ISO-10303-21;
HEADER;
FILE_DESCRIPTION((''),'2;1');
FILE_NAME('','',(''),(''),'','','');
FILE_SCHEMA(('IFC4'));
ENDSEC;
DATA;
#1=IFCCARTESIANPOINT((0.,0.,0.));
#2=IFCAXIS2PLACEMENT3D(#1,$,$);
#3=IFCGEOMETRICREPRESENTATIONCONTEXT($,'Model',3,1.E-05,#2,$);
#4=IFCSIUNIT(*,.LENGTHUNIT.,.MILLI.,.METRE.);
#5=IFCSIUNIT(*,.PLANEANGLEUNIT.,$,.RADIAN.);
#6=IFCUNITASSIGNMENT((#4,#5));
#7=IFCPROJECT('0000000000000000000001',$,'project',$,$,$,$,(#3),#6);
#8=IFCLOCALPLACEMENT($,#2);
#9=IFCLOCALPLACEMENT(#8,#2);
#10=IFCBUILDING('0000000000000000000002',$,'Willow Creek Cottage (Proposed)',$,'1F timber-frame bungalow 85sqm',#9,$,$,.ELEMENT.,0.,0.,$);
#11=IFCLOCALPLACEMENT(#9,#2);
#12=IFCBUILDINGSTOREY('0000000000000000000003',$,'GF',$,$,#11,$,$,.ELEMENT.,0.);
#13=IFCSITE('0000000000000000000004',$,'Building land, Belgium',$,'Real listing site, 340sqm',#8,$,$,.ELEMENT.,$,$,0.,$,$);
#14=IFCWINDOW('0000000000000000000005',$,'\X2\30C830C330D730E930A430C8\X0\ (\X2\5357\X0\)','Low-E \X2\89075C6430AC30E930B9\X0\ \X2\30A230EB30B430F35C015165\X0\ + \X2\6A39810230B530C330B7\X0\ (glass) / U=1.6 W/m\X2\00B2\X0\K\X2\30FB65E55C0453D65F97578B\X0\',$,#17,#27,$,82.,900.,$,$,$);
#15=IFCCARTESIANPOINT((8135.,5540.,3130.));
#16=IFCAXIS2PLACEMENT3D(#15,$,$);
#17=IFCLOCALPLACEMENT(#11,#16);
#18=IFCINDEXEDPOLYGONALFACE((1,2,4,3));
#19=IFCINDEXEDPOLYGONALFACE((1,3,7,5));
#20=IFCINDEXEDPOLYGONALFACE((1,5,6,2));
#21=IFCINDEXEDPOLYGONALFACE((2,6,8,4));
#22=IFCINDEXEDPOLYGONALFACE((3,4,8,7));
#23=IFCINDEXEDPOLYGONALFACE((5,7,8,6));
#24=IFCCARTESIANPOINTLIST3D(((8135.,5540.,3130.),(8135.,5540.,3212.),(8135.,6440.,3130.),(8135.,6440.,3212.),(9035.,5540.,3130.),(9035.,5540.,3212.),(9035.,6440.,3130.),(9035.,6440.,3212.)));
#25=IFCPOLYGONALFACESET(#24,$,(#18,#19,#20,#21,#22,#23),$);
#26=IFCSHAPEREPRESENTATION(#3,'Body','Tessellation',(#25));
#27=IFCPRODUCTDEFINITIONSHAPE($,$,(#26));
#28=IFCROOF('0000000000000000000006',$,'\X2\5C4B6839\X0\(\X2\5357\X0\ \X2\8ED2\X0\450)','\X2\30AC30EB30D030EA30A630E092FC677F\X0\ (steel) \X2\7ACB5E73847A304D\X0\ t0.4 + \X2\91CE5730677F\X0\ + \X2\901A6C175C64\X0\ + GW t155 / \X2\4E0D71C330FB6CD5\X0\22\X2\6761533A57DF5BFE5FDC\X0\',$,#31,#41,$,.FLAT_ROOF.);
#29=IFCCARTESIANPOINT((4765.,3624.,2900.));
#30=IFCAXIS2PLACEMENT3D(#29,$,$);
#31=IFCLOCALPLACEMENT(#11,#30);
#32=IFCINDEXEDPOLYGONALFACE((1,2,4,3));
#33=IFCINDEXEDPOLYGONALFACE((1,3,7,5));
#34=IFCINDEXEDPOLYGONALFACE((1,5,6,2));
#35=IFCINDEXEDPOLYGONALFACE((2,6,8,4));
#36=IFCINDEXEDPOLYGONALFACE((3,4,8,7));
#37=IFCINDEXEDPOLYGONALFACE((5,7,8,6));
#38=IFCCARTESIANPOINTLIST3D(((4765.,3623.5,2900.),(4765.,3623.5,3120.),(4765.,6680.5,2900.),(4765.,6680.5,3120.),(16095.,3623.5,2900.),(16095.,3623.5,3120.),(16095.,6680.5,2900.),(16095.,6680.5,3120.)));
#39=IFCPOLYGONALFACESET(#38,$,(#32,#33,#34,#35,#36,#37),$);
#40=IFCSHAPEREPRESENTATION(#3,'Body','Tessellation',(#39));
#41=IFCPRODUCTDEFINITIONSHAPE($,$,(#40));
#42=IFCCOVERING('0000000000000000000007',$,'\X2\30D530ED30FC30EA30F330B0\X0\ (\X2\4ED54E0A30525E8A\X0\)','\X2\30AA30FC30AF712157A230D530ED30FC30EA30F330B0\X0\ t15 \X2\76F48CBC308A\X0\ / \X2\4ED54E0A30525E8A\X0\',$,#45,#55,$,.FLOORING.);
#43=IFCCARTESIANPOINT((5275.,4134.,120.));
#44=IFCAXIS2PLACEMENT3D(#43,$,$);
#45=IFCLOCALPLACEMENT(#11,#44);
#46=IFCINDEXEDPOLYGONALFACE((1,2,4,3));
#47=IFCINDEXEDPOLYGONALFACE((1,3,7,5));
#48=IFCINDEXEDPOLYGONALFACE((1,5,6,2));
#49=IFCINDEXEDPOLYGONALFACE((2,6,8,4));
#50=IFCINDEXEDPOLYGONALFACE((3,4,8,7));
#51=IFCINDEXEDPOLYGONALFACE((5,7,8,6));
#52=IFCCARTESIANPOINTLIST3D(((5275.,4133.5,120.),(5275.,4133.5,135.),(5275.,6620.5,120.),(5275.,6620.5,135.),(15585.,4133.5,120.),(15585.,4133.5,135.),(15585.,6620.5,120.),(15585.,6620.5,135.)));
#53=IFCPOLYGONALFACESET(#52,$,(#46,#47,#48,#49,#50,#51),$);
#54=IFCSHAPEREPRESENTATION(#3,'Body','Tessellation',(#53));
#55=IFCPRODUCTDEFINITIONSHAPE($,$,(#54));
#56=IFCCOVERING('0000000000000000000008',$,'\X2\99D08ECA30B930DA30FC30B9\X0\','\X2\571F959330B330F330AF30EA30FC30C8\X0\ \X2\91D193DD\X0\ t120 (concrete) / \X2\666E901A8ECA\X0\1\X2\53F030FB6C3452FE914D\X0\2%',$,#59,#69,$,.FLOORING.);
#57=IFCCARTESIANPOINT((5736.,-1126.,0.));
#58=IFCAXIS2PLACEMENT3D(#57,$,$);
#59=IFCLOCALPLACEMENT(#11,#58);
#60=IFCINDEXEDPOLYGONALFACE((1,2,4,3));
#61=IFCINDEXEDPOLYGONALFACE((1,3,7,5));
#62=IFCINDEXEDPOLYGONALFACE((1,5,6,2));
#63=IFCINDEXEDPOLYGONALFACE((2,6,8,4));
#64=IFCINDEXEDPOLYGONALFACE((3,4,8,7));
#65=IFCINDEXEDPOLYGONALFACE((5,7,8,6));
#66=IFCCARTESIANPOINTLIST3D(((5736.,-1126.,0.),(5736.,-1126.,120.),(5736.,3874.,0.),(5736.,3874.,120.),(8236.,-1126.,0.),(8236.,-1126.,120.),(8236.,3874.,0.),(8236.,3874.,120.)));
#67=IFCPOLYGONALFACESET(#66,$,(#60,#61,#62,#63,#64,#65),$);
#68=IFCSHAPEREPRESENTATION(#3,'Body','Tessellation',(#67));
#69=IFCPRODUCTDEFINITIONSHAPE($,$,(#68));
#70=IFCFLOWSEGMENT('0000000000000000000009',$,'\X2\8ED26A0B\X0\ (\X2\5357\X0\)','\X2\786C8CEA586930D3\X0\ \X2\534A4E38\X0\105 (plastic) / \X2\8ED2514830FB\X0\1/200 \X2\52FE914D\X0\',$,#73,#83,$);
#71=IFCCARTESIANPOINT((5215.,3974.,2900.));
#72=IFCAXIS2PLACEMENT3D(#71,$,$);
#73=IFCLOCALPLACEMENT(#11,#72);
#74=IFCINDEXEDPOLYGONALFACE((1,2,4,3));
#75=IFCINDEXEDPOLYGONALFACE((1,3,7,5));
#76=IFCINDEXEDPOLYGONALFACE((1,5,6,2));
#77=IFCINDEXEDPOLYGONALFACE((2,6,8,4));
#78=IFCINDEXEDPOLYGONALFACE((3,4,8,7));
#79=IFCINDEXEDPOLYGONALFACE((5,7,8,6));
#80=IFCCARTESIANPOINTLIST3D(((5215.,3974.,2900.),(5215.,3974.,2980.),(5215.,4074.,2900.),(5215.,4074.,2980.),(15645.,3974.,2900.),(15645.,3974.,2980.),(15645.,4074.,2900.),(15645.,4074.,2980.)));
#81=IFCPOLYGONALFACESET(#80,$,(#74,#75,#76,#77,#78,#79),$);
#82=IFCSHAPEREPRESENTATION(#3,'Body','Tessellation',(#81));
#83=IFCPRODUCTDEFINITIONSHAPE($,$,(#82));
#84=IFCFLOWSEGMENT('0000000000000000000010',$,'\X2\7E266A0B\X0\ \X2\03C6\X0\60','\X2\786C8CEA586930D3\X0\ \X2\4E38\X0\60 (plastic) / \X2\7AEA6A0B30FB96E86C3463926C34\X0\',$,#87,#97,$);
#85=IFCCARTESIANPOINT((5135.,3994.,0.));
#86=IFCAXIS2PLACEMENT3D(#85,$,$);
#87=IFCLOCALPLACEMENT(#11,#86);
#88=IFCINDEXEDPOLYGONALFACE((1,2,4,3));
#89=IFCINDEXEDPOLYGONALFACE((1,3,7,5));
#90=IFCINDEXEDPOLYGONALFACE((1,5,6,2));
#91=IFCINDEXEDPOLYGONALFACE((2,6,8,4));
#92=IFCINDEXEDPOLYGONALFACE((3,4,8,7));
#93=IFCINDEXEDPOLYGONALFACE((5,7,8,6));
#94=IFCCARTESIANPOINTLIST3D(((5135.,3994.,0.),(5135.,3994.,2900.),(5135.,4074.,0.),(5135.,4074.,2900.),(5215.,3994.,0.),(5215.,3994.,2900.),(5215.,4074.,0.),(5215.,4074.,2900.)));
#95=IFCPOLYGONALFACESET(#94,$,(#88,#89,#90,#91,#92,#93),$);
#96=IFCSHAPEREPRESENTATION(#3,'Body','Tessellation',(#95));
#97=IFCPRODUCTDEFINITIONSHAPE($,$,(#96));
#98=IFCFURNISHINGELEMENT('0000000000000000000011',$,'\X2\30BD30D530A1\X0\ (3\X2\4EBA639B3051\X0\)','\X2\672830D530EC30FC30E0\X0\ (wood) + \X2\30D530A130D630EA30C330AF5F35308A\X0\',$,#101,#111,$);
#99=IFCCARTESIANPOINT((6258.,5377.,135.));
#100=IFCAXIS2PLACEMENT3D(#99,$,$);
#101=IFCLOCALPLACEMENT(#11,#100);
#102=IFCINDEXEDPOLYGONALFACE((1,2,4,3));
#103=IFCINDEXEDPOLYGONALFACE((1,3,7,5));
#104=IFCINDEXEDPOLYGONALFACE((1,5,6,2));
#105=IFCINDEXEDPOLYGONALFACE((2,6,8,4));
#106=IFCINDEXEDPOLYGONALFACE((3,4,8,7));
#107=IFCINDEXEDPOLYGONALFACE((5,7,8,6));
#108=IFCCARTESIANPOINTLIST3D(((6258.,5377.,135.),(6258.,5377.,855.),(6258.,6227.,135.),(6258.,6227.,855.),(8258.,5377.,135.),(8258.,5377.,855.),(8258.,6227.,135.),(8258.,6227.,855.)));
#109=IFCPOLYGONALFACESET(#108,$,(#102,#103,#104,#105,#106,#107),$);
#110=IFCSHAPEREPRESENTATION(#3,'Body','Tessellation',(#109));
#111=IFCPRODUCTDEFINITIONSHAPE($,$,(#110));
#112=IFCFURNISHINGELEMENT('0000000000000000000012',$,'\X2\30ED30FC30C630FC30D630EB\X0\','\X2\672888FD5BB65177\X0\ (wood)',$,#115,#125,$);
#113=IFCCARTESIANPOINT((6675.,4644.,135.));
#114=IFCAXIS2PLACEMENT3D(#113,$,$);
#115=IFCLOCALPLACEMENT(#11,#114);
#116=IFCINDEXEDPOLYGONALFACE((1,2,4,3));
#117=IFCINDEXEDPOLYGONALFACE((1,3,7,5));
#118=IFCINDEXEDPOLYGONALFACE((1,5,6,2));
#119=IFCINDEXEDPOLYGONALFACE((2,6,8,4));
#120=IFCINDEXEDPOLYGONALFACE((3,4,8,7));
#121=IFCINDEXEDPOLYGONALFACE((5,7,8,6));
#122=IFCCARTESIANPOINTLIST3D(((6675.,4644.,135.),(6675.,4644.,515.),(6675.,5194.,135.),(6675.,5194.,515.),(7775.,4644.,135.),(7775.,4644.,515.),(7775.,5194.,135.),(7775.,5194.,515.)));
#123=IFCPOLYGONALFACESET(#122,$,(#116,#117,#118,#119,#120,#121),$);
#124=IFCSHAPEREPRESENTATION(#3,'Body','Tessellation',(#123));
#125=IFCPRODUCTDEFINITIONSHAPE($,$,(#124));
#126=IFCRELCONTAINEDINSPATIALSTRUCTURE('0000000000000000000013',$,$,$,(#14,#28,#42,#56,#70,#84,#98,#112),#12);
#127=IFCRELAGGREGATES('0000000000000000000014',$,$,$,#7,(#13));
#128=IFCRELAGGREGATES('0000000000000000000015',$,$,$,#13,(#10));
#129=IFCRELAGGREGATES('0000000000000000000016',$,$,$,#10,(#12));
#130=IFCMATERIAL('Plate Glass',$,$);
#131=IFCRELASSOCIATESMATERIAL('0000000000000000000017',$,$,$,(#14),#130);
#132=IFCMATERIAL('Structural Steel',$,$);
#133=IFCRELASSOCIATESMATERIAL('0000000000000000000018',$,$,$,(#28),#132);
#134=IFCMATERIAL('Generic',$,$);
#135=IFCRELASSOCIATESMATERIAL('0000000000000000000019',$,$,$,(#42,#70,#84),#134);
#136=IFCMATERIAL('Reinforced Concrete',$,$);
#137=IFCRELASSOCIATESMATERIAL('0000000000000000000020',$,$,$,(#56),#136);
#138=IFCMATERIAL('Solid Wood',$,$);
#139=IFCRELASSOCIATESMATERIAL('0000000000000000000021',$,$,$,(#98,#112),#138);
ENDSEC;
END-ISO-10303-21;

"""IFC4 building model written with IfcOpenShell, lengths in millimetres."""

from ifc_helpers import new_model, si_unit, frame, frame_2d, origin, place, context, project, spatial, rectangle, extrude, material, element, save


model = new_model("IFC4")

# Units and contexts
model_context = context("Model", 3, precision=1e-05, world=origin())
ifc_project = project(units=[si_unit("LENGTHUNIT", "METRE", prefix="MILLI"), si_unit("PLANEANGLEUNIT", "RADIAN")], contexts=[model_context])

# Site, building, storey
site_placement = place(None, origin())
site = spatial("IfcSite", under=ifc_project, at=site_placement, Name="Building land, Belgium", ObjectType="Real listing site, 340sqm", CompositionType="ELEMENT", RefElevation=0.0)
building_placement = place(site_placement, origin())
building = spatial("IfcBuilding", under=site, at=building_placement, Name="Willow Creek Cottage (Proposed)", ObjectType="1F timber-frame bungalow 85sqm", CompositionType="ELEMENT", ElevationOfRefHeight=0.0, ElevationOfTerrain=0.0)
storey_placement = place(building_placement, origin())
storey = spatial("IfcBuildingStorey", under=building, at=storey_placement, Name="GF", CompositionType="ELEMENT", Elevation=0.0)

# Shared definitions
ifc_material_1 = material(Name="Solid Wood")

# Shared definitions
ifc_material_2 = material(Name="Reinforced Concrete")

# Shared definitions
ifc_material_3 = material(Name="Plate Glass")

# Window
window_1_placement = place(storey_placement, frame((8135.0, 5540.0, 3130.0)))
element("IfcWindow", 1, at=window_1_placement, inside=storey, material=ifc_material_3, Name="トップライト (南)", Description="Low-E 複層ガラス アルゴン封入 + 樹脂サッシ (glass) / U=1.6 W/m²K・日射取得型", OverallHeight=82.0, OverallWidth=900.0, context=model_context, shape_type="SweptSolid", body=[
    extrude(rectangle(XDim=900.0, YDim=900.0, at=frame_2d((450.0, 450.0))), frame((8135.0, 5540.0, 3130.0)), (0.0, 0.0, 1.0), 82.0),
])

# Roof
ifc_material_4 = material(Name="Structural Steel")
roof_1_placement = place(storey_placement, frame((4765.0, 3624.0, 2900.0)))
element("IfcRoof", 2, at=roof_1_placement, inside=storey, material=ifc_material_4, Name="屋根(南 軒450)", Description="ガルバリウム鋼板 (steel) 立平葺き t0.4 + 野地板 + 通気層 + GW t155 / 不燃・法22条区域対応", PredefinedType="FLAT_ROOF", context=model_context, shape_type="SweptSolid", body=[
    extrude(rectangle(XDim=11330.0, YDim=3057.0, at=frame_2d((5665.0, 1528.0))), frame((4765.0, 3624.0, 2900.0)), (0.0, 0.0, 1.0), 220.0),
])

# Coverings
ifc_material_5 = material(Name="Generic")
covering_1_placement = place(storey_placement, frame((5275.0, 4134.0, 120.0)))
element("IfcCovering", 3, at=covering_1_placement, inside=storey, material=ifc_material_5, Name="フローリング (仕上げ床)", Description="オーク無垢フローリング t15 直貼り / 仕上げ床", PredefinedType="FLOORING", context=model_context, shape_type="SweptSolid", body=[
    extrude(rectangle(XDim=10310.0, YDim=2487.0, at=frame_2d((5155.0, 1243.0))), frame((5275.0, 4134.0, 120.0)), (0.0, 0.0, 1.0), 15.0),
])
covering_2_placement = place(storey_placement, frame((5736.0, -1126.0, 0.0)))
element("IfcCovering", 4, at=covering_2_placement, inside=storey, material=ifc_material_2, Name="駐車スペース", Description="土間コンクリート 金鏝 t120 (concrete) / 普通車1台・水勾配2%", PredefinedType="FLOORING", context=model_context, shape_type="SweptSolid", body=[
    extrude(rectangle(XDim=2500.0, YDim=5000.0, at=frame_2d((1250.0, 2500.0))), frame((5736.0, -1126.0, 0.0)), (0.0, 0.0, 1.0), 120.0),
])

# Flow segments
flow_segment_1_placement = place(storey_placement, frame((5215.0, 3974.0, 2900.0)))
element("IfcFlowSegment", 5, at=flow_segment_1_placement, inside=storey, material=ifc_material_5, Name="軒樋 (南)", Description="硬質塩ビ 半丸105 (plastic) / 軒先・1/200 勾配", context=model_context, shape_type="SweptSolid", body=[
    extrude(rectangle(XDim=10430.0, YDim=100.0, at=frame_2d((5215.0, 50.0))), frame((5215.0, 3974.0, 2900.0)), (0.0, 0.0, 1.0), 80.0),
])
flow_segment_2_placement = place(storey_placement, frame((5135.0, 3994.0, 0.0)))
element("IfcFlowSegment", 6, at=flow_segment_2_placement, inside=storey, material=ifc_material_5, Name="縦樋 φ60", Description="硬質塩ビ 丸60 (plastic) / 竪樋・雨水排水", context=model_context, shape_type="SweptSolid", body=[
    extrude(rectangle(XDim=80.0, YDim=80.0, at=frame_2d((40.0, 40.0))), frame((5135.0, 3994.0, 0.0)), (0.0, 0.0, 1.0), 2900.0),
])

# Furnishing elements
furnishing_1_placement = place(storey_placement, frame((6258.0, 5377.0, 135.0)))
element("IfcFurnishingElement", 7, at=furnishing_1_placement, inside=storey, material=ifc_material_1, Name="ソファ (3人掛け)", Description="木フレーム (wood) + ファブリック張り", context=model_context, shape_type="SweptSolid", body=[
    extrude(rectangle(XDim=2000.0, YDim=850.0, at=frame_2d((1000.0, 425.0))), frame((6258.0, 5377.0, 135.0)), (0.0, 0.0, 1.0), 720.0),
])
furnishing_2_placement = place(storey_placement, frame((6675.0, 4644.0, 135.0)))
element("IfcFurnishingElement", 8, at=furnishing_2_placement, inside=storey, material=ifc_material_1, Name="ローテーブル", Description="木製家具 (wood)", context=model_context, shape_type="SweptSolid", body=[
    extrude(rectangle(XDim=1100.0, YDim=550.0, at=frame_2d((550.0, 275.0))), frame((6675.0, 4644.0, 135.0)), (0.0, 0.0, 1.0), 380.0),
])

save(model, "model.ifc")
